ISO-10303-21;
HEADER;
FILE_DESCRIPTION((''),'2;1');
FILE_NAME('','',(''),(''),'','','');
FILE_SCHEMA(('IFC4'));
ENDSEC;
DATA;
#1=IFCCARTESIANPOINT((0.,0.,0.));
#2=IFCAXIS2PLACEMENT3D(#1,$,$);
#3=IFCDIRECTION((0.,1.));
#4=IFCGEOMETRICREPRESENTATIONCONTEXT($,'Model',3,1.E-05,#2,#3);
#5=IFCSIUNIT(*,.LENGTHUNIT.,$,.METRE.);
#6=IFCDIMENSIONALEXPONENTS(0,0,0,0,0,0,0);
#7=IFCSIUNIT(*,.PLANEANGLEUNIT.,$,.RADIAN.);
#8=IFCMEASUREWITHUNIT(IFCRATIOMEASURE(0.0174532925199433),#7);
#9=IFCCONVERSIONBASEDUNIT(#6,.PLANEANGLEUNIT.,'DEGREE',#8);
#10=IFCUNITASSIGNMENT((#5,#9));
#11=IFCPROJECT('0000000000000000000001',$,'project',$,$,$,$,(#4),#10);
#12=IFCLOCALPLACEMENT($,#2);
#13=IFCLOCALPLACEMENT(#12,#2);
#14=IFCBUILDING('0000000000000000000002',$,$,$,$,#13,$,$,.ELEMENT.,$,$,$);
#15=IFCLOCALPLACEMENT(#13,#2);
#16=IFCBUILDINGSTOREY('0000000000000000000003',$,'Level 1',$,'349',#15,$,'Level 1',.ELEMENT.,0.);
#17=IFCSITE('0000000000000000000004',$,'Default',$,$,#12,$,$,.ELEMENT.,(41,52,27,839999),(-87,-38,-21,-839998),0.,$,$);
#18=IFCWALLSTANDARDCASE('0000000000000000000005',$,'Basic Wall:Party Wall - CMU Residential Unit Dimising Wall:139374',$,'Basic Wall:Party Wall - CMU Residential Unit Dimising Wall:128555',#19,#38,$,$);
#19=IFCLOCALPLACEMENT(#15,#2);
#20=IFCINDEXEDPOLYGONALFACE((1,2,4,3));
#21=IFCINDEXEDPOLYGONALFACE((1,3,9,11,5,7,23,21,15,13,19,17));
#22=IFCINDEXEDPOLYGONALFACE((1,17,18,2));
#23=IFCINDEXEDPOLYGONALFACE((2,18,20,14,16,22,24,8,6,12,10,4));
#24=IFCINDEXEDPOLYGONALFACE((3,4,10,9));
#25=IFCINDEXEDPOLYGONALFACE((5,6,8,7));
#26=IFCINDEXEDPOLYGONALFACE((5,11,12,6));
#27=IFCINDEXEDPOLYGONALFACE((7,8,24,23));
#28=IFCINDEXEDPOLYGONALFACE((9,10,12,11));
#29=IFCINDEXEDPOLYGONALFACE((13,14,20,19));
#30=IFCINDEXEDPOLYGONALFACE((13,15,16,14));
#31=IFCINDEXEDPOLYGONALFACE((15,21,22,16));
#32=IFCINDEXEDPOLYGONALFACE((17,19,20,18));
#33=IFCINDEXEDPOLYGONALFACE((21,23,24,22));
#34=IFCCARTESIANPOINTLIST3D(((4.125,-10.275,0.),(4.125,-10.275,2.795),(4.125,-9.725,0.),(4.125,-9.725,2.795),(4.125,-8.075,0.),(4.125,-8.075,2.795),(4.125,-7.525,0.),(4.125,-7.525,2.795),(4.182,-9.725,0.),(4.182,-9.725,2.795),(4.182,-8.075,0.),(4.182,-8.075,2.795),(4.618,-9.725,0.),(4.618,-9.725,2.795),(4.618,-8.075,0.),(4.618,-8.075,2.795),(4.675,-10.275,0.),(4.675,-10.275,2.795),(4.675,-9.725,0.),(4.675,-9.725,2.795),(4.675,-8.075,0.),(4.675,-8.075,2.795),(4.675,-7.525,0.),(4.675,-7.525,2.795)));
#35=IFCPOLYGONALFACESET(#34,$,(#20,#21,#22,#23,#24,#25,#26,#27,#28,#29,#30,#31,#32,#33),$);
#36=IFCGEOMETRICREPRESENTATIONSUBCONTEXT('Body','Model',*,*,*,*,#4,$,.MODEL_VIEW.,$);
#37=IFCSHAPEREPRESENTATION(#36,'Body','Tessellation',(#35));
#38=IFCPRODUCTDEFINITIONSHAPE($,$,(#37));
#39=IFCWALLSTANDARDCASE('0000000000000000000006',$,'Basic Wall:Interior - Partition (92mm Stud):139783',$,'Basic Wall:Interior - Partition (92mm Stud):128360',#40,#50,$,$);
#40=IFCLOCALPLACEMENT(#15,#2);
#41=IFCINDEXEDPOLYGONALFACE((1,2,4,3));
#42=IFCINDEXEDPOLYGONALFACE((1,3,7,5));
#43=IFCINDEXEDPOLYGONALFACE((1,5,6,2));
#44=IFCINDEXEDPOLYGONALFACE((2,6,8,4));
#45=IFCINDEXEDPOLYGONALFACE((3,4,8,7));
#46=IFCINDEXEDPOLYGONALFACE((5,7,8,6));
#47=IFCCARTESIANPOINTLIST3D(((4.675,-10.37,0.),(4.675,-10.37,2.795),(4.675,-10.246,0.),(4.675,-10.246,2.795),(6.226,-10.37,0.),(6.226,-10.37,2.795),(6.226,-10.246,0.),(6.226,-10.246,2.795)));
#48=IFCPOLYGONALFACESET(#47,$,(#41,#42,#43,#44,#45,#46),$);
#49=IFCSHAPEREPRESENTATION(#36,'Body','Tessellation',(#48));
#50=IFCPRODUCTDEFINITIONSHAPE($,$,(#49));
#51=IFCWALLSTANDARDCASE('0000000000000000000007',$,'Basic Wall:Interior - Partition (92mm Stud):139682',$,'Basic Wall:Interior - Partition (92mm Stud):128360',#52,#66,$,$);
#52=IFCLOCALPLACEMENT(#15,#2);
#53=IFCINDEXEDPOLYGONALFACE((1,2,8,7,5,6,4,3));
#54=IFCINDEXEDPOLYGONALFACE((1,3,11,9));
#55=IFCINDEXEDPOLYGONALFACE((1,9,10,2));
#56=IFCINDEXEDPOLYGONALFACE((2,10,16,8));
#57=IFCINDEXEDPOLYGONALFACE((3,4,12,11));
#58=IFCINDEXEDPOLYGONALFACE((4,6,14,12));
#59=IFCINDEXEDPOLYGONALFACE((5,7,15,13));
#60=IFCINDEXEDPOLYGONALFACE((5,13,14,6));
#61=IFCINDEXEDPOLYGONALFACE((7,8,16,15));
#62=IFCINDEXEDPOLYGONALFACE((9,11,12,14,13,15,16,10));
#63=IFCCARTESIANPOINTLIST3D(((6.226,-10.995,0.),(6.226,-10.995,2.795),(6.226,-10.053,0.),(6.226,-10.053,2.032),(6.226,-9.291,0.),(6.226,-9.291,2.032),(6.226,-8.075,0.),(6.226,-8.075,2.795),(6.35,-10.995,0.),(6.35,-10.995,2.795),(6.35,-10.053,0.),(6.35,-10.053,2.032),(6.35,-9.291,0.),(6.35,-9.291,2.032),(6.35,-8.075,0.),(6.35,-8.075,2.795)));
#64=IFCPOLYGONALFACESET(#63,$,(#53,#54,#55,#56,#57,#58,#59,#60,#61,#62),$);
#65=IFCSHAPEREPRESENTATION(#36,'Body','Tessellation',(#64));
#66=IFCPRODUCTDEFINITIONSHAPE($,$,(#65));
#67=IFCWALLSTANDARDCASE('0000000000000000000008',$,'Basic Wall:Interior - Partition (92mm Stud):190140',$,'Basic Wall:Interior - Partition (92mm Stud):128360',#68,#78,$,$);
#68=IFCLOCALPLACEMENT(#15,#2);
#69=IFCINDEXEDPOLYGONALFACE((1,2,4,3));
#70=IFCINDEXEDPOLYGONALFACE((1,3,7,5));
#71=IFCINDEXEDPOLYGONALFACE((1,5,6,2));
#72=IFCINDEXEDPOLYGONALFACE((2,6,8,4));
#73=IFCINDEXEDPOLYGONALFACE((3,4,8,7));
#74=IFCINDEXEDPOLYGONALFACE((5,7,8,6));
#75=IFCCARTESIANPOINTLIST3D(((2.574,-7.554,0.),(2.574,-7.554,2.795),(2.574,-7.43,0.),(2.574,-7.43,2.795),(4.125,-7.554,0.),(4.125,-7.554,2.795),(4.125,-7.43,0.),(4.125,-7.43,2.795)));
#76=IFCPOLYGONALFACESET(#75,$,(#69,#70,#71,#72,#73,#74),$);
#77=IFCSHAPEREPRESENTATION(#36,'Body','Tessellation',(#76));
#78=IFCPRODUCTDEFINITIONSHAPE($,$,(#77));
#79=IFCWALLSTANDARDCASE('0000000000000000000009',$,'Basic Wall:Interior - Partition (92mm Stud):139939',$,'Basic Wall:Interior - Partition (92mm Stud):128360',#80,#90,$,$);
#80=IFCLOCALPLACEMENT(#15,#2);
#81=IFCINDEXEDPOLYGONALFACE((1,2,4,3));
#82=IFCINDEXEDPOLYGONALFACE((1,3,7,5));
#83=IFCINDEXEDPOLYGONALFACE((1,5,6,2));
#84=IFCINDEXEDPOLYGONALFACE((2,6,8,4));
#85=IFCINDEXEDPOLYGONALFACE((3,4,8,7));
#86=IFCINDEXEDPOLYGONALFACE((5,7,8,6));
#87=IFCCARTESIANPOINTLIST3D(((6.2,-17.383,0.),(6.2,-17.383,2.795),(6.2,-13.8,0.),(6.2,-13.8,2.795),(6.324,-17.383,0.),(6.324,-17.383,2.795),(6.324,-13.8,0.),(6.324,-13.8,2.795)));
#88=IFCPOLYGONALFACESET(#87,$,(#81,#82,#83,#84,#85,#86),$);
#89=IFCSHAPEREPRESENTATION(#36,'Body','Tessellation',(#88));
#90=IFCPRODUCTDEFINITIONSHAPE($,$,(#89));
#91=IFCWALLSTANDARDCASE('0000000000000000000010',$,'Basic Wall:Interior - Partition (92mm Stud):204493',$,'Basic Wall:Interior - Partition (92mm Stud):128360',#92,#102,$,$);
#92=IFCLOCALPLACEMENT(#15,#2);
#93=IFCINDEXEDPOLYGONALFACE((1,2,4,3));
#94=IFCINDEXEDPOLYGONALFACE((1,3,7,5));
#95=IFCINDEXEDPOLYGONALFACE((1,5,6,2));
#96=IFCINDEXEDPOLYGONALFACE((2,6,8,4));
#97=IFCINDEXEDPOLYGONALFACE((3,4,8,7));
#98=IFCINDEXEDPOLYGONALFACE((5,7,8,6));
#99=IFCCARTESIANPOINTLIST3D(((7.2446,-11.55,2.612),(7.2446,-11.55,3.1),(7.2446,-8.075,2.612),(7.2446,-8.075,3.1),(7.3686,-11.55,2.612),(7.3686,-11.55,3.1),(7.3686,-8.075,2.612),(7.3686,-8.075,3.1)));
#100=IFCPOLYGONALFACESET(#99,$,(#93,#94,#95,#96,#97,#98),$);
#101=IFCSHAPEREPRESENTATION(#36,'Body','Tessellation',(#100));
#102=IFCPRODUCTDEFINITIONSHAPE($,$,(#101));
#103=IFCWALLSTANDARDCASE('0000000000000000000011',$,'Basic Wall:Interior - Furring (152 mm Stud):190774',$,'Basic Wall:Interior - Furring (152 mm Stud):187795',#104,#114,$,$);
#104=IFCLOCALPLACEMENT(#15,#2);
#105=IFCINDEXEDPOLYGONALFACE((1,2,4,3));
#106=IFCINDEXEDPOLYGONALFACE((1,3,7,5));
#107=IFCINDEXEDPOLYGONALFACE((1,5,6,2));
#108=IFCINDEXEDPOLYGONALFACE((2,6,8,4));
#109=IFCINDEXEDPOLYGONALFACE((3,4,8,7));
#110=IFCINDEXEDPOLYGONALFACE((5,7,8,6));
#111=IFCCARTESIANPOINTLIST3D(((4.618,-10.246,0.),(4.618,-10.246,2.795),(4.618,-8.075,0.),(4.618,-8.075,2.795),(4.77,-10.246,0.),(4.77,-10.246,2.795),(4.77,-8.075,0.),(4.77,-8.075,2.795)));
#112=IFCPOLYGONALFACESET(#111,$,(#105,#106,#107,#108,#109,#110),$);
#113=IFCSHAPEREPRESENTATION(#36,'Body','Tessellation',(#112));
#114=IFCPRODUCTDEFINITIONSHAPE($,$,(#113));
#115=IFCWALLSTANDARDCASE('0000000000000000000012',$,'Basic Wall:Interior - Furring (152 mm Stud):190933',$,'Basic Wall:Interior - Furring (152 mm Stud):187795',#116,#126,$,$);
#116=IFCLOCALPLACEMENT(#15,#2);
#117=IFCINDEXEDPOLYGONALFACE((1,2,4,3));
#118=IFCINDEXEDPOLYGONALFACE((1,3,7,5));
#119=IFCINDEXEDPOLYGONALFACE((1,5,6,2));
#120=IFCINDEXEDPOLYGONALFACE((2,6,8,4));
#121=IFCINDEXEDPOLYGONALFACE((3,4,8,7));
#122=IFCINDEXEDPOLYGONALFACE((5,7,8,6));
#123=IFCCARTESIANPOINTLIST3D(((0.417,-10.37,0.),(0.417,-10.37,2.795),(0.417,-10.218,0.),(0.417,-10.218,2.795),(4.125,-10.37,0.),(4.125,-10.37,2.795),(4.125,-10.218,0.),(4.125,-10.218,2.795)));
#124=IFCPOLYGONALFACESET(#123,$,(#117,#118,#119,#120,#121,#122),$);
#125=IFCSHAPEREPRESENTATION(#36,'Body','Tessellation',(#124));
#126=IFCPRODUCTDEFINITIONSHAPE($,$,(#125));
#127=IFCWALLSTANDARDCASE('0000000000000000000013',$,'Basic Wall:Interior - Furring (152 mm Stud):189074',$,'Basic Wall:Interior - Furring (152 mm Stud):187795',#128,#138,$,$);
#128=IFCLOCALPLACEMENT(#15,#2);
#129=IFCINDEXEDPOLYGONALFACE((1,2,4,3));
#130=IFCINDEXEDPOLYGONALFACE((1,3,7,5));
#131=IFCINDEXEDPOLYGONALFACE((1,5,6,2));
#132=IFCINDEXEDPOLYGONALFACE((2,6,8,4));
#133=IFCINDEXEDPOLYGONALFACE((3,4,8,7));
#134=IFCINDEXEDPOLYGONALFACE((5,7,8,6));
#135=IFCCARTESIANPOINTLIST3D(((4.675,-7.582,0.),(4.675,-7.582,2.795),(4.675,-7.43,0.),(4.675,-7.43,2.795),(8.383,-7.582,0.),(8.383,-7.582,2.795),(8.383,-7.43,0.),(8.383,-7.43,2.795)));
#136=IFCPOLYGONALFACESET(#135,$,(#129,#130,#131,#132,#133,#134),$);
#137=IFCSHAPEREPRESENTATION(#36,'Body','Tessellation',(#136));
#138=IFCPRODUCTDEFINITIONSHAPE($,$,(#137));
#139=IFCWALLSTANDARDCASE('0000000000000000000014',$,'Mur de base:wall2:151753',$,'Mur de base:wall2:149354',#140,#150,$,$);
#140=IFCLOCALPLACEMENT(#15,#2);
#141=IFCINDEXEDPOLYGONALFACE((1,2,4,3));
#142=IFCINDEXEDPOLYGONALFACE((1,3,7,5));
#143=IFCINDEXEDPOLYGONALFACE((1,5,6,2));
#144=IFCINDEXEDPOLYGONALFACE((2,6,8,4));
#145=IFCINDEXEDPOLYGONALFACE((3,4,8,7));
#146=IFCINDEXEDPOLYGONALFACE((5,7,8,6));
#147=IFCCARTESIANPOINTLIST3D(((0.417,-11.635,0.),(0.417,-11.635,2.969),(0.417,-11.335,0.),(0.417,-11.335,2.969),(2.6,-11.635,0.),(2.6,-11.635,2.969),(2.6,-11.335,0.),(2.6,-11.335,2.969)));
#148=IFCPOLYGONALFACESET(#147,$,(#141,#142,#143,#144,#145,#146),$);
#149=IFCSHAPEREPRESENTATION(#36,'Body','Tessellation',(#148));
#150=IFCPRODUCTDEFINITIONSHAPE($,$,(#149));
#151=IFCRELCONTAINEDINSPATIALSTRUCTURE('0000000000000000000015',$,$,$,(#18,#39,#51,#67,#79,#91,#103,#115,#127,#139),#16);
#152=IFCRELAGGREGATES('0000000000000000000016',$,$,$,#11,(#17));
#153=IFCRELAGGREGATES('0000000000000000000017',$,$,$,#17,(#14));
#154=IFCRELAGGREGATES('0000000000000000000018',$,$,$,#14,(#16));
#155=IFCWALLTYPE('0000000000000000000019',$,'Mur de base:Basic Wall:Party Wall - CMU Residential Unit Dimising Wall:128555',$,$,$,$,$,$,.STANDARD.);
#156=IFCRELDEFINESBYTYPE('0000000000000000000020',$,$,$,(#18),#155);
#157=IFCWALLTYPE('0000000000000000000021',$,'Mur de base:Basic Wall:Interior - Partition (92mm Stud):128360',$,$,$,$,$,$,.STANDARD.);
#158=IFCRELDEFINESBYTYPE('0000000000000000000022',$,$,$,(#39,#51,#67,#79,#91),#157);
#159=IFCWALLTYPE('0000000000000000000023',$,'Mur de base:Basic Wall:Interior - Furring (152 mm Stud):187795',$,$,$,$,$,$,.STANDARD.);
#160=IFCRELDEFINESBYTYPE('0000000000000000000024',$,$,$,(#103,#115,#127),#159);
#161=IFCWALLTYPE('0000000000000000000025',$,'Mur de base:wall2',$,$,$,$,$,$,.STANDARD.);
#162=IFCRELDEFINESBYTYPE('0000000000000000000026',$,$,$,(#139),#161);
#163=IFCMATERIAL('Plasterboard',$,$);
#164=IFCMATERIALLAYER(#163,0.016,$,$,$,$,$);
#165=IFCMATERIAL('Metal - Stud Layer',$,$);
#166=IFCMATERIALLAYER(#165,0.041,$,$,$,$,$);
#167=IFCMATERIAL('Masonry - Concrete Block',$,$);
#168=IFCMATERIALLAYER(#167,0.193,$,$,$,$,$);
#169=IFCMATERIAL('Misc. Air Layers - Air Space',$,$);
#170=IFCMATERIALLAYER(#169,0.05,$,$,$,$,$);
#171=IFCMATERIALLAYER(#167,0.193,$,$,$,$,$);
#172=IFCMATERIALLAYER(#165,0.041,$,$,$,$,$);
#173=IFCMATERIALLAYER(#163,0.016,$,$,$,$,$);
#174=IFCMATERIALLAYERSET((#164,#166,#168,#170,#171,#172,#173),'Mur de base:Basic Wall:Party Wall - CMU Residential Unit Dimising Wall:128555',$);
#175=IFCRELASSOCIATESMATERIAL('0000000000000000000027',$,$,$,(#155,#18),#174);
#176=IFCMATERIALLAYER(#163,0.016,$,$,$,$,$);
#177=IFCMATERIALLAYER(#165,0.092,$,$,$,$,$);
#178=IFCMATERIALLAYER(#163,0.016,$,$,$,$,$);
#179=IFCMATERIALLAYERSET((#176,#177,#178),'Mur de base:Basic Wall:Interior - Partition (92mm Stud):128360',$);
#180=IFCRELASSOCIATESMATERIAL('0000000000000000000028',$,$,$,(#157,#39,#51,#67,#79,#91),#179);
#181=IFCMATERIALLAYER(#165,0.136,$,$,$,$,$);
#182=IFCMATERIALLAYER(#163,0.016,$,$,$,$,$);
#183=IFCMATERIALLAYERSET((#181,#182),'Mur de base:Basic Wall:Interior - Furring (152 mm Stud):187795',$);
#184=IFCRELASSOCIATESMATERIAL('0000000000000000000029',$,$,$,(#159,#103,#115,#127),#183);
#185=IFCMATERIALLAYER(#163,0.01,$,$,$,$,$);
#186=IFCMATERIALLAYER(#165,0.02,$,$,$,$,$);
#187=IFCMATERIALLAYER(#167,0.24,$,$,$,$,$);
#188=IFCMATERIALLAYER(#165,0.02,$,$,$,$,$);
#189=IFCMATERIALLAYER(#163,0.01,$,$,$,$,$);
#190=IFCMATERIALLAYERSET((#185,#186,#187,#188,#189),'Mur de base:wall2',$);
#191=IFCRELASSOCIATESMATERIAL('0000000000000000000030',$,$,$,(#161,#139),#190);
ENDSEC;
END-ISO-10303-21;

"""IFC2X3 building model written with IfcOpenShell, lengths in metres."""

from ifc_helpers import new_model, entity, si_unit, converted_unit, direction, frame, frame_2d, origin, origin_2d_with_axis, place, context, subcontext, project, spatial, polyline, rectangle, extrude, clip, bounded_halfspace, material, layer, layer_set, layer_usage, type_object, element, save


model = new_model("IFC2X3")

# Units and contexts
model_context = context("Model", 3, precision=1e-05, world=origin(), true_north=direction((0.0, 1.0)))
body_context = subcontext(model_context, "Body", "Model", "MODEL_VIEW")
ifc_project = project(units=[si_unit("LENGTHUNIT", "METRE"), converted_unit("PLANEANGLEUNIT", "DEGREE", entity("IfcRatioMeasure", 0.0174532925199433), si_unit("PLANEANGLEUNIT", "RADIAN"), dimensions=[0, 0, 0, 0, 0, 0, 0])], contexts=[model_context])

# Site, building, storey
site_placement = place(None, origin())
site = spatial("IfcSite", under=ifc_project, at=site_placement, Name="Default", CompositionType="ELEMENT", RefLatitude=(41, 52, 27, 839999), RefLongitude=(-87, -38, -21, -839998), RefElevation=0.0)
building_placement = place(site_placement, origin())
building = spatial("IfcBuilding", under=site, at=building_placement, CompositionType="ELEMENT")
storey_placement = place(building_placement, origin())
storey = spatial("IfcBuildingStorey", under=building, at=storey_placement, Name="Level 1", ObjectType="349", LongName="Level 1", CompositionType="ELEMENT", Elevation=0.0)

# Wall, opening
ifc_material_1 = material(Name="Plasterboard")
ifc_layer_1 = layer(ifc_material_1, 0.016)
ifc_material_2 = material(Name="Metal - Stud Layer")
ifc_layer_2 = layer(ifc_material_2, 0.041)
ifc_material_3 = material(Name="Masonry - Concrete Block")
ifc_layer_3 = layer(ifc_material_3, 0.193)
ifc_material_4 = material(Name="Misc. Air Layers - Air Space")
ifc_layer_4 = layer(ifc_material_4, 0.05)
ifc_layer_5 = layer(ifc_material_3, 0.193)
ifc_layer_6 = layer(ifc_material_2, 0.041)
ifc_layer_7 = layer(ifc_material_1, 0.016)
ifc_layer_set_1 = layer_set([ifc_layer_1, ifc_layer_2, ifc_layer_3, ifc_layer_4, ifc_layer_5, ifc_layer_6, ifc_layer_7], Name="Mur de base:Basic Wall:Party Wall - CMU Residential Unit Dimising Wall:128555")
ifc_layer_usage_1 = layer_usage(ifc_layer_set_1, "AXIS2", "NEGATIVE", 0.275)
wall_type_1 = type_object("IfcWallType", Name="Mur de base:Basic Wall:Party Wall - CMU Residential Unit Dimising Wall:128555", PredefinedType="STANDARD", material=ifc_layer_set_1)
wall_1_placement = place(storey_placement, frame((4.4, -10.275, 0.0), z_axis=(0.0, 0.0, 1.0), x_axis=(0.0, 1.0, 0.0)))
wall_1 = element("IfcWallStandardCase", 1, at=wall_1_placement, inside=storey, type_object=wall_type_1, material=ifc_layer_usage_1, Name="Basic Wall:Party Wall - CMU Residential Unit Dimising Wall:139374", ObjectType="Basic Wall:Party Wall - CMU Residential Unit Dimising Wall:128555", context=body_context, shape_type="SweptSolid", body=[
    extrude(rectangle(XDim=2.75, YDim=0.55, at=frame_2d((1.375, 0.0), x_axis=(-1.0, 0.0))), origin(), (0.0, 0.0, 1.0), 2.795),
])
opening_1_placement = place(wall_1_placement, origin())
element("IfcOpeningElement", 2, at=opening_1_placement, cuts=wall_1, ObjectType="Opening", context=body_context, shape_type="SweptSolid", body=[
    extrude(rectangle(XDim=2.795, YDim=1.65, at=origin_2d_with_axis()), frame((1.375, 0.218, 1.3975), z_axis=(0.0, 1.0, 0.0), x_axis=(0.0, 0.0, 1.0)), (0.0, 0.0, 1.0), 3.904),
    extrude(rectangle(XDim=2.795, YDim=1.65, at=frame_2d((0.0, 0.0), x_axis=(0.0, 1.0))), frame((1.375, -4.122, 1.3975), z_axis=(0.0, 1.0, 0.0), x_axis=(-1.0, 0.0, 0.0)), (0.0, 0.0, 1.0), 3.904),
])

# Wall
ifc_layer_8 = layer(ifc_material_1, 0.016)
ifc_layer_9 = layer(ifc_material_2, 0.092)
ifc_layer_10 = layer(ifc_material_1, 0.016)
ifc_layer_set_2 = layer_set([ifc_layer_8, ifc_layer_9, ifc_layer_10], Name="Mur de base:Basic Wall:Interior - Partition (92mm Stud):128360")
ifc_layer_usage_2 = layer_usage(ifc_layer_set_2, "AXIS2", "NEGATIVE", 0.062)
wall_type_2 = type_object("IfcWallType", Name="Mur de base:Basic Wall:Interior - Partition (92mm Stud):128360", PredefinedType="STANDARD", material=ifc_layer_set_2)
wall_2_placement = place(storey_placement, frame((4.675, -10.308, 0.0)))
element("IfcWallStandardCase", 3, at=wall_2_placement, inside=storey, type_object=wall_type_2, material=ifc_layer_usage_2, Name="Basic Wall:Interior - Partition (92mm Stud):139783", ObjectType="Basic Wall:Interior - Partition (92mm Stud):128360", context=body_context, shape_type="SweptSolid", body=[
    extrude(rectangle(XDim=1.551, YDim=0.124, at=frame_2d((0.7755, 0.0), x_axis=(-1.0, 0.0))), origin(), (0.0, 0.0, 1.0), 2.795),
])

# Wall, opening
ifc_layer_usage_3 = layer_usage(ifc_layer_set_2, "AXIS2", "NEGATIVE", 0.062)
wall_3_placement = place(storey_placement, frame((6.288, -10.995, 0.0), z_axis=(0.0, 0.0, 1.0), x_axis=(0.0, 1.0, 0.0)))
wall_3 = element("IfcWallStandardCase", 4, at=wall_3_placement, inside=storey, type_object=wall_type_2, material=ifc_layer_usage_3, Name="Basic Wall:Interior - Partition (92mm Stud):139682", ObjectType="Basic Wall:Interior - Partition (92mm Stud):128360", context=body_context, shape_type="SweptSolid", body=[
    extrude(rectangle(XDim=2.92, YDim=0.124, at=frame_2d((1.46, 0.0), x_axis=(-1.0, 0.0))), origin(), (0.0, 0.0, 1.0), 2.795),
])
opening_2_placement = place(wall_3_placement, origin())
element("IfcOpeningElement", 5, at=opening_2_placement, cuts=wall_3, ObjectType="Opening", context=body_context, shape_type="SweptSolid", body=[
    extrude(rectangle(XDim=2.032, YDim=0.762, at=origin_2d_with_axis()), frame((1.323, -0.0632, 1.016), z_axis=(0.0, 1.0, 0.0), x_axis=(0.0, 0.0, 1.0)), (0.0, 0.0, 1.0), 0.1265),
])

# Walls
ifc_layer_usage_4 = layer_usage(ifc_layer_set_2, "AXIS2", "NEGATIVE", 0.062)
wall_4_placement = place(storey_placement, frame((4.125, -7.492, 0.0), z_axis=(0.0, 0.0, 1.0), x_axis=(-1.0, 0.0, 0.0)))
element("IfcWallStandardCase", 6, at=wall_4_placement, inside=storey, type_object=wall_type_2, material=ifc_layer_usage_4, Name="Basic Wall:Interior - Partition (92mm Stud):190140", ObjectType="Basic Wall:Interior - Partition (92mm Stud):128360", context=body_context, shape_type="SweptSolid", body=[
    extrude(rectangle(XDim=1.551, YDim=0.124, at=frame_2d((0.7755, 0.0), x_axis=(-1.0, 0.0))), origin(), (0.0, 0.0, 1.0), 2.795),
])
ifc_layer_usage_5 = layer_usage(ifc_layer_set_2, "AXIS2", "NEGATIVE", 0.062)
wall_5_placement = place(storey_placement, frame((6.262, -13.8, 0.0), z_axis=(0.0, 0.0, 1.0), x_axis=(0.0, -1.0, 0.0)))
element("IfcWallStandardCase", 7, at=wall_5_placement, inside=storey, type_object=wall_type_2, material=ifc_layer_usage_5, Name="Basic Wall:Interior - Partition (92mm Stud):139939", ObjectType="Basic Wall:Interior - Partition (92mm Stud):128360", context=body_context, shape_type="SweptSolid", body=[
    extrude(rectangle(XDim=3.583, YDim=0.124, at=frame_2d((1.7915, 0.0), x_axis=(-1.0, 0.0))), origin(), (0.0, 0.0, 1.0), 2.795),
])
ifc_layer_usage_6 = layer_usage(ifc_layer_set_2, "AXIS2", "NEGATIVE", 0.062)
wall_6_placement = place(storey_placement, frame((7.3066, -11.55, 2.612), z_axis=(0.0, 0.0, 1.0), x_axis=(0.0, 1.0, 0.0)))
element("IfcWallStandardCase", 8, at=wall_6_placement, inside=storey, type_object=wall_type_2, material=ifc_layer_usage_6, Name="Basic Wall:Interior - Partition (92mm Stud):204493", ObjectType="Basic Wall:Interior - Partition (92mm Stud):128360", context=body_context, shape_type="SweptSolid", body=[
    extrude(rectangle(XDim=3.475, YDim=0.124, at=frame_2d((1.7375, 0.0), x_axis=(-1.0, 0.0))), origin(), (0.0, 0.0, 1.0), 0.488),
])

# Walls
ifc_layer_11 = layer(ifc_material_2, 0.136)
ifc_layer_12 = layer(ifc_material_1, 0.016)
ifc_layer_set_3 = layer_set([ifc_layer_11, ifc_layer_12], Name="Mur de base:Basic Wall:Interior - Furring (152 mm Stud):187795")
ifc_layer_usage_7 = layer_usage(ifc_layer_set_3, "AXIS2", "NEGATIVE", 0.076)
wall_type_3 = type_object("IfcWallType", Name="Mur de base:Basic Wall:Interior - Furring (152 mm Stud):187795", PredefinedType="STANDARD", material=ifc_layer_set_3)
wall_7_placement = place(storey_placement, frame((4.694, -10.246, 0.0), z_axis=(0.0, 0.0, 1.0), x_axis=(0.0, 1.0, 0.0)))
element("IfcWallStandardCase", 9, at=wall_7_placement, inside=storey, type_object=wall_type_3, material=ifc_layer_usage_7, Name="Basic Wall:Interior - Furring (152 mm Stud):190774", ObjectType="Basic Wall:Interior - Furring (152 mm Stud):187795", context=body_context, shape_type="SweptSolid", body=[
    extrude(rectangle(XDim=2.171, YDim=0.152, at=frame_2d((1.0855, 0.0), x_axis=(-1.0, 0.0))), origin(), (0.0, 0.0, 1.0), 2.795),
])
ifc_layer_usage_8 = layer_usage(ifc_layer_set_3, "AXIS2", "NEGATIVE", 0.076)
wall_8_placement = place(storey_placement, frame((0.417, -10.294, 0.0)))
element("IfcWallStandardCase", 10, at=wall_8_placement, inside=storey, type_object=wall_type_3, material=ifc_layer_usage_8, Name="Basic Wall:Interior - Furring (152 mm Stud):190933", ObjectType="Basic Wall:Interior - Furring (152 mm Stud):187795", context=body_context, shape_type="SweptSolid", body=[
    extrude(rectangle(XDim=3.708, YDim=0.152, at=frame_2d((1.854, 0.0), x_axis=(-1.0, 0.0))), origin(), (0.0, 0.0, 1.0), 2.795),
])
ifc_layer_usage_9 = layer_usage(ifc_layer_set_3, "AXIS2", "NEGATIVE", 0.076)
wall_9_placement = place(storey_placement, frame((8.383, -7.506, 0.0), z_axis=(0.0, 0.0, 1.0), x_axis=(-1.0, 0.0, 0.0)))
element("IfcWallStandardCase", 11, at=wall_9_placement, inside=storey, type_object=wall_type_3, material=ifc_layer_usage_9, Name="Basic Wall:Interior - Furring (152 mm Stud):189074", ObjectType="Basic Wall:Interior - Furring (152 mm Stud):187795", context=body_context, shape_type="SweptSolid", body=[
    extrude(rectangle(XDim=3.708, YDim=0.152, at=frame_2d((1.854, 0.0), x_axis=(-1.0, 0.0))), origin(), (0.0, 0.0, 1.0), 2.795),
])
ifc_layer_13 = layer(ifc_material_1, 0.01)
ifc_layer_14 = layer(ifc_material_2, 0.02)
ifc_layer_15 = layer(ifc_material_3, 0.24)
ifc_layer_16 = layer(ifc_material_2, 0.02)
ifc_layer_17 = layer(ifc_material_1, 0.01)
ifc_layer_set_4 = layer_set([ifc_layer_13, ifc_layer_14, ifc_layer_15, ifc_layer_16, ifc_layer_17], Name="Mur de base:wall2")
ifc_layer_usage_10 = layer_usage(ifc_layer_set_4, "AXIS2", "NEGATIVE", 0.15)
wall_type_4 = type_object("IfcWallType", Name="Mur de base:wall2", PredefinedType="STANDARD", material=ifc_layer_set_4)
wall_10_placement = place(storey_placement, frame((0.417, -11.485, 0.0)))
element("IfcWallStandardCase", 12, at=wall_10_placement, inside=storey, type_object=wall_type_4, material=ifc_layer_usage_10, Name="Mur de base:wall2:151753", ObjectType="Mur de base:wall2:149354", context=body_context, shape_type="Clipping", body=[
    clip(extrude(rectangle(XDim=2.183, YDim=0.3, at=frame_2d((1.0915, 0.0), x_axis=(-1.0, 0.0))), origin(), (0.0, 0.0, 1.0), 2.969), bounded_halfspace(frame((0.0, -0.15, 2.969), z_axis=(0.0, 0.0, -1.0), x_axis=(-1.0, 0.0, 0.0)), True, frame((0.0, -0.15, 2.969)), polyline([(0.0, 0.0), (2.183, 0.0), (2.183, 0.3), (0.0, 0.3), (0.0, 0.0)]))),
])

save(model, "model.ifc")
